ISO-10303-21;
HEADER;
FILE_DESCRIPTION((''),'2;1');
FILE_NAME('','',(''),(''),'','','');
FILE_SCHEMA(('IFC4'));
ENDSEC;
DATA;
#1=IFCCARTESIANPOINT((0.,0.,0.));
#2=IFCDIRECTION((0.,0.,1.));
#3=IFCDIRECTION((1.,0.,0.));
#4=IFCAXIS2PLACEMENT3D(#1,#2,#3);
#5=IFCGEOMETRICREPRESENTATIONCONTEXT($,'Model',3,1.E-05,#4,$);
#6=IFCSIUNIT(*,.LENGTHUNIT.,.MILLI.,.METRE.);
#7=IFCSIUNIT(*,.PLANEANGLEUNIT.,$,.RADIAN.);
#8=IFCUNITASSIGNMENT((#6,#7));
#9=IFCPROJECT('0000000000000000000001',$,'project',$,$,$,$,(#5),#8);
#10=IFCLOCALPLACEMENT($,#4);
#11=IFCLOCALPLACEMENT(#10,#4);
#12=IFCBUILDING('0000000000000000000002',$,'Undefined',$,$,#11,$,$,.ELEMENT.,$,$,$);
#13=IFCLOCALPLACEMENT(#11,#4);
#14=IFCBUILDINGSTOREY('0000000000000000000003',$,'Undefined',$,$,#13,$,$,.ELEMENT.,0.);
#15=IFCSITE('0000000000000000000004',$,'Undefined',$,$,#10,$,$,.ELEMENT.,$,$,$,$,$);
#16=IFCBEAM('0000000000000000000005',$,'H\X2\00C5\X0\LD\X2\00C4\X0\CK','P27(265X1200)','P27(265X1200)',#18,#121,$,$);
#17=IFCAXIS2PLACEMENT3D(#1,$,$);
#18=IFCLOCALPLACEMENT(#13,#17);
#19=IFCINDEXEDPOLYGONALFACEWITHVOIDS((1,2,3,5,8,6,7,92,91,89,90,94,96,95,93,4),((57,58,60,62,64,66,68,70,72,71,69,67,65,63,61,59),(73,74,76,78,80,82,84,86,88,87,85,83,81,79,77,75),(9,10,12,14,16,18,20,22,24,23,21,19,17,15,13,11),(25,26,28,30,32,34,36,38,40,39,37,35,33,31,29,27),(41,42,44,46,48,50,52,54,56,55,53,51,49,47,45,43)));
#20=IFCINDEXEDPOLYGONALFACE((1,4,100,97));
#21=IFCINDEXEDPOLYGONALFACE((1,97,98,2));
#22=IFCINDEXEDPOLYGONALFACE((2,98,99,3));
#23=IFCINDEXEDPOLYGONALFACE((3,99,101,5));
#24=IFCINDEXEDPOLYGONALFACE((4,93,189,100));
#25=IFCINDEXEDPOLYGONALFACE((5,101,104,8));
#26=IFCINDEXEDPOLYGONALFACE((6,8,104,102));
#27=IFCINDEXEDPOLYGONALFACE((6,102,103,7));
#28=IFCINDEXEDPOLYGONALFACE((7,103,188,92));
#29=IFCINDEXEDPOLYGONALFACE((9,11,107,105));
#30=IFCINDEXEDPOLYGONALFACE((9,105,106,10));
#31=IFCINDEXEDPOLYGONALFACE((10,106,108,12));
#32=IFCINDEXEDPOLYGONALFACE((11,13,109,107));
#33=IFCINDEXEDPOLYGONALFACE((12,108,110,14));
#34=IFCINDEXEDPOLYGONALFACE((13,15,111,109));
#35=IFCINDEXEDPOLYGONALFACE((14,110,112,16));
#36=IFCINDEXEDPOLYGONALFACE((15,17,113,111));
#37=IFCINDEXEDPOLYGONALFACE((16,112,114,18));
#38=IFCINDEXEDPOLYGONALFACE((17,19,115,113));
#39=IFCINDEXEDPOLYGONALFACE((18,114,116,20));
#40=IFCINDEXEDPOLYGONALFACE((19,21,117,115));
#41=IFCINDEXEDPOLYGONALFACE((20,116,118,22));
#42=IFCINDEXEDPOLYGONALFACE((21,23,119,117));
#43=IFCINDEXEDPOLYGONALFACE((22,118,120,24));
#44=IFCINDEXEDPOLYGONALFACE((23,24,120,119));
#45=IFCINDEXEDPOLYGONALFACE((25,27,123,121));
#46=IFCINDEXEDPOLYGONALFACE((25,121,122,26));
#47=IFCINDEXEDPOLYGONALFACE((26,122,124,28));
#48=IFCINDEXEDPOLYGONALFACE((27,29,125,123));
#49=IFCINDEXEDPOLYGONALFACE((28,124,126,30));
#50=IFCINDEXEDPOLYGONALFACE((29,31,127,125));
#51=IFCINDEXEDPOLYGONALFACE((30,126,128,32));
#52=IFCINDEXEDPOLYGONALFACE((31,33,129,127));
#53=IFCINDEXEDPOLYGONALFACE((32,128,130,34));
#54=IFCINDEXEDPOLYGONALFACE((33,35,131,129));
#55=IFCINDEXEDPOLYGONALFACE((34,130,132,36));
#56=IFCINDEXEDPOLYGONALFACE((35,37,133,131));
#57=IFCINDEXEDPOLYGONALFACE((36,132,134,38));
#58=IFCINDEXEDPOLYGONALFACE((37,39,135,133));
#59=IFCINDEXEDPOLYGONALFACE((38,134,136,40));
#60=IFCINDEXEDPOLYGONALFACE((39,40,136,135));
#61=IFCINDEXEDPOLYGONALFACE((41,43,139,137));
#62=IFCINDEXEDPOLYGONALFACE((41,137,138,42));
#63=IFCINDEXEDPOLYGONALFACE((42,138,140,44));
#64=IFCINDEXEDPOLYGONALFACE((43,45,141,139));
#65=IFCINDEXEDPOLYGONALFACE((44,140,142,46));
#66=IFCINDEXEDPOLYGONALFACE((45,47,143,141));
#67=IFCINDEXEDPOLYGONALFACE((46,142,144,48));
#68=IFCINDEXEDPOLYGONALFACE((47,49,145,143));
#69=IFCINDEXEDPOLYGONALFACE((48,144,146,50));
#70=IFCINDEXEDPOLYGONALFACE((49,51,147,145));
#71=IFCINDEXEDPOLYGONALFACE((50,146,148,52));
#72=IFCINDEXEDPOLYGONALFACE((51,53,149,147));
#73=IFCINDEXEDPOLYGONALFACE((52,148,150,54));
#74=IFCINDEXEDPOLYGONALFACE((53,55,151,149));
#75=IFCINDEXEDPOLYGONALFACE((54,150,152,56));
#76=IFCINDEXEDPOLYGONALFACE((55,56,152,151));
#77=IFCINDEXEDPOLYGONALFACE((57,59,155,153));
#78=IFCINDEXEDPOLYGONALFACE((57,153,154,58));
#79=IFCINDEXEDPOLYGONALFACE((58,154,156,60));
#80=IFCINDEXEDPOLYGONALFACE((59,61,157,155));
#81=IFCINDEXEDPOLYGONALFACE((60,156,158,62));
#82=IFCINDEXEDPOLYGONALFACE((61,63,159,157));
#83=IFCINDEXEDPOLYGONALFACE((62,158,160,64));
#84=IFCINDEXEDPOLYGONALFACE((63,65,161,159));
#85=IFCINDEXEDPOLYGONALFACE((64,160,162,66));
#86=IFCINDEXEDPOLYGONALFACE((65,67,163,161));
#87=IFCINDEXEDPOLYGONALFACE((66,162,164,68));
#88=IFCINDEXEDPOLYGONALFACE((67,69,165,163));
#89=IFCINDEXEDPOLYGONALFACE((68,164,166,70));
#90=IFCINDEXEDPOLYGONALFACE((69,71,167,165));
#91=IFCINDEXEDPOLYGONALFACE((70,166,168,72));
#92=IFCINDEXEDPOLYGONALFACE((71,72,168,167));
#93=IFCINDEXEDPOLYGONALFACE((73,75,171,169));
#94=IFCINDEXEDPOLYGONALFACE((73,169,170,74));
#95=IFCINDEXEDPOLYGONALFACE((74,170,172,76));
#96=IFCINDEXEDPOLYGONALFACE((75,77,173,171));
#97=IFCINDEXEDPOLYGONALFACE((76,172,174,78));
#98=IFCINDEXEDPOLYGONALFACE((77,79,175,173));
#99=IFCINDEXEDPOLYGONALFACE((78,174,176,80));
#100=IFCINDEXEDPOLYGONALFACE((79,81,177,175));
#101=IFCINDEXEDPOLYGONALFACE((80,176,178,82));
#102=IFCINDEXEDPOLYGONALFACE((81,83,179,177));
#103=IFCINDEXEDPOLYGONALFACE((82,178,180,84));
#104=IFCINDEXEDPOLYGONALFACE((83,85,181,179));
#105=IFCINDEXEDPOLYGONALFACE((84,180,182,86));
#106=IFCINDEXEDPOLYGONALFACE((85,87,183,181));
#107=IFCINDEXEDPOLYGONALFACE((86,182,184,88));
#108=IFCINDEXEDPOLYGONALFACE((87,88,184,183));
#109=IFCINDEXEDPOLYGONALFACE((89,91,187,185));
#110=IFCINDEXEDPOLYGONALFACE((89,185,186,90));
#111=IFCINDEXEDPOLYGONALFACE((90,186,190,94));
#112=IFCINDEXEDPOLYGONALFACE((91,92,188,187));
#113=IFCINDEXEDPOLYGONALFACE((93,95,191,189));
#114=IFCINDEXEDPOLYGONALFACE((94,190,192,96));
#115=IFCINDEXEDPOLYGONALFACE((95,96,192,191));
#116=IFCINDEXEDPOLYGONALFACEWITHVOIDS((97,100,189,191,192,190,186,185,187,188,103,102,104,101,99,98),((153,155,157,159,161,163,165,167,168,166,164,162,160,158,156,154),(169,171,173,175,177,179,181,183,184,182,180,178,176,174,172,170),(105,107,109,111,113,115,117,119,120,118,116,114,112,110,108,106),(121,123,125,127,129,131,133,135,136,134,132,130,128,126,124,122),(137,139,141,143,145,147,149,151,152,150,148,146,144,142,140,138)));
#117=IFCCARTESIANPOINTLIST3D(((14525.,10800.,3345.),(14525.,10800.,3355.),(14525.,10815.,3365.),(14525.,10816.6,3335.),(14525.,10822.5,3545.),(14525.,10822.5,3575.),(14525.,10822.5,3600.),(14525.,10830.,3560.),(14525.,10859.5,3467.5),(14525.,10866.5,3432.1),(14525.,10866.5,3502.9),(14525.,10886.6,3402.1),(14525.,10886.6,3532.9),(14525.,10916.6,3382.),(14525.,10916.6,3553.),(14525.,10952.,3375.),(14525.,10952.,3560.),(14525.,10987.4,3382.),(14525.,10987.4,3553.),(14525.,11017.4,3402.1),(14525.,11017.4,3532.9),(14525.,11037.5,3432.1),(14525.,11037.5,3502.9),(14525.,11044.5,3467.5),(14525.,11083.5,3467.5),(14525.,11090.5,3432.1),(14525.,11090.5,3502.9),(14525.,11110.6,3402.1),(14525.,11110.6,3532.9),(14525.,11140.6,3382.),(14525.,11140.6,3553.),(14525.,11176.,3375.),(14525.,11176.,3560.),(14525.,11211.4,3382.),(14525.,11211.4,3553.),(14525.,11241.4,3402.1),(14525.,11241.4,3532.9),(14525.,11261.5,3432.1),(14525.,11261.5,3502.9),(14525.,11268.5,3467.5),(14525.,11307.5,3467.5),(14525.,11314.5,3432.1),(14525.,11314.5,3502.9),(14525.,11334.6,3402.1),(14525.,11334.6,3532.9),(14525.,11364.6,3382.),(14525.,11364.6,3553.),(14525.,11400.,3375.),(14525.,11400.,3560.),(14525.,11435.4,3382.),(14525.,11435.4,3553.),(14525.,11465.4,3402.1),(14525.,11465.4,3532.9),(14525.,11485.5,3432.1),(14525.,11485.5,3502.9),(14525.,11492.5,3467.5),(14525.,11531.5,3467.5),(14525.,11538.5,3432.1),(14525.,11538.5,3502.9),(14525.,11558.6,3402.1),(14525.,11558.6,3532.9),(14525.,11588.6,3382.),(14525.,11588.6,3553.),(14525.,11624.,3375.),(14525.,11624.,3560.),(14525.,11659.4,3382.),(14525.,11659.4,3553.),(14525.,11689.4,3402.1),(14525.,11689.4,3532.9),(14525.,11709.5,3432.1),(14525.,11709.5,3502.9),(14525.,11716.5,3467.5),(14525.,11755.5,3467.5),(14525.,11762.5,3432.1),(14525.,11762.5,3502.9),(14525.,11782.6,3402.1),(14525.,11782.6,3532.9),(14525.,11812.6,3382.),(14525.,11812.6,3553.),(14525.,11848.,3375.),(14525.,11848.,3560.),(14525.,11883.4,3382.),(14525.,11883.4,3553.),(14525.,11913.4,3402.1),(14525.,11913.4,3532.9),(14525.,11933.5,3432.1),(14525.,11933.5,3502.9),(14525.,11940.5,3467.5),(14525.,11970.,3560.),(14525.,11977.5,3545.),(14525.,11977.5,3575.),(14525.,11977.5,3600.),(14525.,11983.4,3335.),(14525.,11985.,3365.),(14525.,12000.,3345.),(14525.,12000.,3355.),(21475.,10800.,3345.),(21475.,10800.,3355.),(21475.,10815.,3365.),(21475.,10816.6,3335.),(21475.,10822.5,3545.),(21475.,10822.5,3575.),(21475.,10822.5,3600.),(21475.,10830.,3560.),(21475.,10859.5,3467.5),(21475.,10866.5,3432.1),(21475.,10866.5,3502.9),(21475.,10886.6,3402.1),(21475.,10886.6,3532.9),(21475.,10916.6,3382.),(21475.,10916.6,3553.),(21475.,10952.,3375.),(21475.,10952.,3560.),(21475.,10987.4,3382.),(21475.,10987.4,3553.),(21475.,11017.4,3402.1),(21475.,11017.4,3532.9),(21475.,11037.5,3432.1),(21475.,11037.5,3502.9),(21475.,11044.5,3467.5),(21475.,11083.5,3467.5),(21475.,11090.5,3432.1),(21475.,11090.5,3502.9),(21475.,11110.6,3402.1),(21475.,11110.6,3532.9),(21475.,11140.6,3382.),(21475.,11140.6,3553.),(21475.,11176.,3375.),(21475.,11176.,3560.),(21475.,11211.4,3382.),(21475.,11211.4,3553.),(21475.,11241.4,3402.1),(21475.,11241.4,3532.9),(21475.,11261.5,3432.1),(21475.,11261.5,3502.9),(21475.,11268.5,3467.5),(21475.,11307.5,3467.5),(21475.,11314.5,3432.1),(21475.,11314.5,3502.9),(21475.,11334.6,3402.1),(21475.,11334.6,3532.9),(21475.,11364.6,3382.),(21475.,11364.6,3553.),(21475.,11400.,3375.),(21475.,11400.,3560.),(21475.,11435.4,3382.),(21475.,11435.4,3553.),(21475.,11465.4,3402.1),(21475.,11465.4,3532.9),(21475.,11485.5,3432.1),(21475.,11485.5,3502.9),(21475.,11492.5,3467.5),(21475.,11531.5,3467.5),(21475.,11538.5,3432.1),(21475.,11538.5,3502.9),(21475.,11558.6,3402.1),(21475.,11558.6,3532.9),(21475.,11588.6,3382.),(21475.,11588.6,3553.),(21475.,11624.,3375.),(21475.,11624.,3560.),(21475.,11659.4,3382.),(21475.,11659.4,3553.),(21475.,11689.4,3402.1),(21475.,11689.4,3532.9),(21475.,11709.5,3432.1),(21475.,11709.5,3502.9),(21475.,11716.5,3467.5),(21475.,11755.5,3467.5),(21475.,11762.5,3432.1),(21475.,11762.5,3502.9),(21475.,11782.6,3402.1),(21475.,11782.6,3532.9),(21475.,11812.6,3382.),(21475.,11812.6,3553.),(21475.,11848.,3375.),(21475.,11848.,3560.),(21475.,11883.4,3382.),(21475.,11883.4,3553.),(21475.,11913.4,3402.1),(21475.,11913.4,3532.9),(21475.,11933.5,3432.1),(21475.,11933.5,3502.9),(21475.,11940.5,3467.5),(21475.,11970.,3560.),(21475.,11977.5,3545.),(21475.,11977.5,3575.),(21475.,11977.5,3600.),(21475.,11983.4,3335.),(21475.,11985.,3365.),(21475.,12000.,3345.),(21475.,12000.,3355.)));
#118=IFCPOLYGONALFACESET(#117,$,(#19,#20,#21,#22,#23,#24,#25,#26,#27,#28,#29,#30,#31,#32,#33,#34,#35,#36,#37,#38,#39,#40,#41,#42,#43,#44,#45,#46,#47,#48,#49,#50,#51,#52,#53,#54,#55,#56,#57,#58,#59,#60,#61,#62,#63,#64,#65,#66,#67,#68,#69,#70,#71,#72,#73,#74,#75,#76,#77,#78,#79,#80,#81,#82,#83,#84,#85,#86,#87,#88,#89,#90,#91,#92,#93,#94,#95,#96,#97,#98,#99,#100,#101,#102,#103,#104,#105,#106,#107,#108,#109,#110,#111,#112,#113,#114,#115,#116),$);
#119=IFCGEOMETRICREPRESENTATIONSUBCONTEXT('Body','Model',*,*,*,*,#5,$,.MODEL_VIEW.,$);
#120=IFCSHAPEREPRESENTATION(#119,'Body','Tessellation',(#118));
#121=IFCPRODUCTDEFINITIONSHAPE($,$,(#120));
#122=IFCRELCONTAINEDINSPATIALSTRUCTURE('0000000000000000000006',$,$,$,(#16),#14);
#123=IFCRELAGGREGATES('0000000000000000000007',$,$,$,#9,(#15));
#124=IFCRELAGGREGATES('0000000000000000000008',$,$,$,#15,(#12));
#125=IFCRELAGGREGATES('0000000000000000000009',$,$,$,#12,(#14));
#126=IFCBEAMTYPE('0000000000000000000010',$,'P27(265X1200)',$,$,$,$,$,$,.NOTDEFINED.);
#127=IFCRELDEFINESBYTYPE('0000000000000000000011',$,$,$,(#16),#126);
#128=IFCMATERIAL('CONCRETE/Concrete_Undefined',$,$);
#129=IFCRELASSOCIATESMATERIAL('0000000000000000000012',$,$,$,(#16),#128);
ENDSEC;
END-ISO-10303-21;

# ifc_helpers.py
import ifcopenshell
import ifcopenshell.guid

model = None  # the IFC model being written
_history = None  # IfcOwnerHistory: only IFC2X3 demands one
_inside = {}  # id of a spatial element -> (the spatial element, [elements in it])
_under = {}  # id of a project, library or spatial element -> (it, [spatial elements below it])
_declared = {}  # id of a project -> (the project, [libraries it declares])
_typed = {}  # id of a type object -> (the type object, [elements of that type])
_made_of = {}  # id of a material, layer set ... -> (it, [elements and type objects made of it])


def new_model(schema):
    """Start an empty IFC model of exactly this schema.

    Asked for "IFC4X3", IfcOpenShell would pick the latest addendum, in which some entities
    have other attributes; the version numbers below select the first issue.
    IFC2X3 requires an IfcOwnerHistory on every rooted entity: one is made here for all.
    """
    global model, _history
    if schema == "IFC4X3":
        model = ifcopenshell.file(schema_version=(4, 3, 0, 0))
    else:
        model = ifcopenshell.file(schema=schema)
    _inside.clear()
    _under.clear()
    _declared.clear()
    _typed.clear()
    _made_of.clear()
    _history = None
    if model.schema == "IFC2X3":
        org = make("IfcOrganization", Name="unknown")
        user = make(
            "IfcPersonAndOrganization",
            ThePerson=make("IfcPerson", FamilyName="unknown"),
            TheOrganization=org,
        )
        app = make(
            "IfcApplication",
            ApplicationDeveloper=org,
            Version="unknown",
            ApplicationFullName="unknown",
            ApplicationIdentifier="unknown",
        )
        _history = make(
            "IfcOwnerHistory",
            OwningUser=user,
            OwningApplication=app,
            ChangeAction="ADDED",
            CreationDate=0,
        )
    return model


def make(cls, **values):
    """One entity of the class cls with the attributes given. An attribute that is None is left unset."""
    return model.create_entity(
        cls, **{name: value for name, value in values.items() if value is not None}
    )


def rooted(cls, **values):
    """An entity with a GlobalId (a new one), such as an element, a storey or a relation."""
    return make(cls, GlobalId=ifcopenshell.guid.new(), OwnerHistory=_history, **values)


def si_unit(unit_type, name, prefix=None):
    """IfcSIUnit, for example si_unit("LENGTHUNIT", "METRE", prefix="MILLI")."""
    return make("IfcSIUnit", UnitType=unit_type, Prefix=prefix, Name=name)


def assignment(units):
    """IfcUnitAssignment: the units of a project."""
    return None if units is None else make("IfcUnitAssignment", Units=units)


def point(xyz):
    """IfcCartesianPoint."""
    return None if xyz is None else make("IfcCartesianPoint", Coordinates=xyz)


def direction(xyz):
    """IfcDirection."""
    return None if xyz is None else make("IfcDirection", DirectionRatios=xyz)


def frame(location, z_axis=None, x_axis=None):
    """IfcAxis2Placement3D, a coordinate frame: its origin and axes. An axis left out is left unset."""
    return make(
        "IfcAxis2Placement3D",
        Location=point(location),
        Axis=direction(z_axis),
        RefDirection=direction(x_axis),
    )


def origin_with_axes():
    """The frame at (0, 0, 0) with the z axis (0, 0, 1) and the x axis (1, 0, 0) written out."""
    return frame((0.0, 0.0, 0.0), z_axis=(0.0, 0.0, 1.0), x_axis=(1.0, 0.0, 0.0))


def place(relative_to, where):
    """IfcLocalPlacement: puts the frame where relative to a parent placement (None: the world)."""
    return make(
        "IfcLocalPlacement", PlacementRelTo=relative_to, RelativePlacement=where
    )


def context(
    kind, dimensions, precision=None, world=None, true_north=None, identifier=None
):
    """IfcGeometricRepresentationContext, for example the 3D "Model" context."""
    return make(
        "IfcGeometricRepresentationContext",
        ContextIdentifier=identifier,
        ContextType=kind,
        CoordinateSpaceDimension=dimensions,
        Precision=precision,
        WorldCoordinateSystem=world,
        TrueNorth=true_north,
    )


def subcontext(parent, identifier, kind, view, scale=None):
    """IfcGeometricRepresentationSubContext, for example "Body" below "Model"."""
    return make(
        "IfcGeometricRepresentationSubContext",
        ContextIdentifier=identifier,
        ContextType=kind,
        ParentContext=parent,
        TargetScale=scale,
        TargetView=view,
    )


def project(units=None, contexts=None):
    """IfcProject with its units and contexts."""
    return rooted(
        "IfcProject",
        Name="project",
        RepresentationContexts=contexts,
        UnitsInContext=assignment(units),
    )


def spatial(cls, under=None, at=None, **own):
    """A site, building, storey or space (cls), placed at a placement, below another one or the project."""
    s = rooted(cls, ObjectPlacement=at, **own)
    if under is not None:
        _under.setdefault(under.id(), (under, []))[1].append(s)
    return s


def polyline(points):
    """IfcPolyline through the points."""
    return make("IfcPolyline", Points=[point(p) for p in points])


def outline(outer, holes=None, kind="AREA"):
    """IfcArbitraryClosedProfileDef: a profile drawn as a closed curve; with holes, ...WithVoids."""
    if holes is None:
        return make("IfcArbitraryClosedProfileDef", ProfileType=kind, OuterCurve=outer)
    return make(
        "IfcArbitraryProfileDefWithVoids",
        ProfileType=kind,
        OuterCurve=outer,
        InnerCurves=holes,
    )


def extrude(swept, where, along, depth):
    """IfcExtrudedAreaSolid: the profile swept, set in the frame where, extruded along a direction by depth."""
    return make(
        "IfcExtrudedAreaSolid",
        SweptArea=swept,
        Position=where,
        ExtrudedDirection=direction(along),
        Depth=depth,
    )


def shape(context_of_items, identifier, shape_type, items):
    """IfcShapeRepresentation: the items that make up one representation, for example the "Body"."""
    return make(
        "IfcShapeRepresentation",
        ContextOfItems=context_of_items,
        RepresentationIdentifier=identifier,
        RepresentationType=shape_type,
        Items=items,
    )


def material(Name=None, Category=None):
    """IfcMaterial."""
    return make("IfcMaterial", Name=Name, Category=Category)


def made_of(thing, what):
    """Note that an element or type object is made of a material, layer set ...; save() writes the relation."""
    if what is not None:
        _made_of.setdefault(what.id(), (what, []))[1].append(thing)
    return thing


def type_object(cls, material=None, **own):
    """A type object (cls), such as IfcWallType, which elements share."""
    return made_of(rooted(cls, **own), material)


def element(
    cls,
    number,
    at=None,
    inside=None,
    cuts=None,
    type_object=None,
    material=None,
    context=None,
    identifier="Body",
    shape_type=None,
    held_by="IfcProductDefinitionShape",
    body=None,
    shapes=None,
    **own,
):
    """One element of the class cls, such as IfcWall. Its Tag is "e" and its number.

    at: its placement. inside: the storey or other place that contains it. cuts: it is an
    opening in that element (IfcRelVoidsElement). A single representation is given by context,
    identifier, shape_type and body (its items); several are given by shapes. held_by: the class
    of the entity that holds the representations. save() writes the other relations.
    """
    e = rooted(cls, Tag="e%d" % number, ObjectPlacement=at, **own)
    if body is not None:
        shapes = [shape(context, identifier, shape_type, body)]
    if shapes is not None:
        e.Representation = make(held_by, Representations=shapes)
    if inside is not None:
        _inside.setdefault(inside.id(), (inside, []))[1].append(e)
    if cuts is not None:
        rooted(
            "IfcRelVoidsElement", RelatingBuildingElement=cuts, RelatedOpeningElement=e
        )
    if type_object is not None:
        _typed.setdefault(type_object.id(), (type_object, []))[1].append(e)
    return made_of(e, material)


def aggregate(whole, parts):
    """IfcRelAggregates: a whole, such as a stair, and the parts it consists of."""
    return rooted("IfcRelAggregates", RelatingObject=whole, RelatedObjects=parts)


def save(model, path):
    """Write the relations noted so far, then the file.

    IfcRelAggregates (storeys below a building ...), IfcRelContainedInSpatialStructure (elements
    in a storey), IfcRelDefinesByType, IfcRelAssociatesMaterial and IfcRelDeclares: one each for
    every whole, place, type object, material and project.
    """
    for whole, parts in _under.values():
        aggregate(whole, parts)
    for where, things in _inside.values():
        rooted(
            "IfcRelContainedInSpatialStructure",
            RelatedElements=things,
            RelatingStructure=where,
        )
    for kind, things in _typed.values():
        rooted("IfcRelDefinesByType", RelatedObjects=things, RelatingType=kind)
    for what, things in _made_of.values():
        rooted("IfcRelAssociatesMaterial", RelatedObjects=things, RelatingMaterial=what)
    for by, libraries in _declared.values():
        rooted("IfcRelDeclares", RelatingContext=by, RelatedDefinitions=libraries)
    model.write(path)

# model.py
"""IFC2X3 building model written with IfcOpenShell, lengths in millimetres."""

from ifc_helpers import new_model, si_unit, frame, origin_with_axes, place, context, subcontext, project, spatial, polyline, outline, extrude, material, type_object, element, save


model = new_model("IFC2X3")

# Units and contexts
model_context = context("Model", 3, precision=1e-05, world=origin_with_axes())
body_context = subcontext(model_context, "Body", "Model", "MODEL_VIEW")
ifc_project = project(units=[si_unit("LENGTHUNIT", "METRE", prefix="MILLI"), si_unit("PLANEANGLEUNIT", "RADIAN")], contexts=[model_context])

# Site, building, storey
site_placement = place(None, origin_with_axes())
site = spatial("IfcSite", under=ifc_project, at=site_placement, Name="Undefined", CompositionType="ELEMENT")
building_placement = place(site_placement, origin_with_axes())
building = spatial("IfcBuilding", under=site, at=building_placement, Name="Undefined", CompositionType="ELEMENT")
storey_placement = place(building_placement, origin_with_axes())
storey = spatial("IfcBuildingStorey", under=building, at=storey_placement, Name="Undefined", CompositionType="ELEMENT", Elevation=0.0)

# Beam
ifc_material_1 = material(Name="CONCRETE/Concrete_Undefined")
beam_type_1 = type_object("IfcBeamType", Name="P27(265X1200)", PredefinedType="NOTDEFINED")
beam_1_placement = place(storey_placement, frame((14525.0, 11400.0, 3467.5), z_axis=(0.0, 0.0, 1.0), x_axis=(1.0, 0.0, 0.0)))
element("IfcBeam", 1, at=beam_1_placement, inside=storey, type_object=beam_type_1, material=ifc_material_1, Name="HÅLDÄCK", Description="P27(265X1200)", ObjectType="P27(265X1200)", context=body_context, shape_type="SweptSolid", body=[
    extrude(outline(polyline([(-583.4, -132.5), (-600.0, -122.5), (-600.0, -112.5), (-585.0, -102.5), (-577.5, 77.5), (-570.0, 92.5), (-577.5, 107.5), (-577.5, 132.5), (577.5, 132.5), (577.5, 107.5), (570.0, 92.5), (577.5, 77.5), (585.0, -102.5), (600.0, -112.5), (600.0, -122.5), (583.4, -132.5), (-583.4, -132.5)]), holes=[polyline([(-513.4, 65.4), (-533.5, 35.4), (-540.5, 0.0), (-533.5, -35.4), (-513.4, -65.4), (-483.4, -85.5), (-448.0, -92.5), (-412.6, -85.5), (-382.6, -65.4), (-362.5, -35.4), (-355.5, 0.0), (-362.5, 35.4), (-382.6, 65.4), (-412.6, 85.5), (-448.0, 92.5), (-483.4, 85.5), (-513.4, 65.4)]), polyline([(-289.4, 65.4), (-309.5, 35.4), (-316.5, 0.0), (-309.5, -35.4), (-289.4, -65.4), (-259.4, -85.5), (-224.0, -92.5), (-188.6, -85.5), (-158.6, -65.4), (-138.5, -35.4), (-131.5, 0.0), (-138.5, 35.4), (-158.6, 65.4), (-188.6, 85.5), (-224.0, 92.5), (-259.4, 85.5), (-289.4, 65.4)]), polyline([(-65.4, 65.4), (-85.5, 35.4), (-92.5, 0.0), (-85.5, -35.4), (-65.4, -65.4), (-35.4, -85.5), (0.0, -92.5), (35.4, -85.5), (65.4, -65.4), (85.5, -35.4), (92.5, 0.0), (85.5, 35.4), (65.4, 65.4), (35.4, 85.5), (0.0, 92.5), (-35.4, 85.5), (-65.4, 65.4)]), polyline([(158.6, 65.4), (138.5, 35.4), (131.5, 0.0), (138.5, -35.4), (158.6, -65.4), (188.6, -85.5), (224.0, -92.5), (259.4, -85.5), (289.4, -65.4), (309.5, -35.4), (316.5, 0.0), (309.5, 35.4), (289.4, 65.4), (259.4, 85.5), (224.0, 92.5), (188.6, 85.5), (158.6, 65.4)]), polyline([(382.6, 65.4), (362.5, 35.4), (355.5, 0.0), (362.5, -35.4), (382.6, -65.4), (412.6, -85.5), (448.0, -92.5), (483.4, -85.5), (513.4, -65.4), (533.5, -35.4), (540.5, 0.0), (533.5, 35.4), (513.4, 65.4), (483.4, 85.5), (448.0, 92.5), (412.6, 85.5), (382.6, 65.4)])]), frame((6950.0, 0.0, 0.0), z_axis=(-1.0, 0.0, 0.0), x_axis=(0.0, -1.0, 0.0)), (0.0, 0.0, 1.0), 6950.0),
])

save(model, "model.ifc")
